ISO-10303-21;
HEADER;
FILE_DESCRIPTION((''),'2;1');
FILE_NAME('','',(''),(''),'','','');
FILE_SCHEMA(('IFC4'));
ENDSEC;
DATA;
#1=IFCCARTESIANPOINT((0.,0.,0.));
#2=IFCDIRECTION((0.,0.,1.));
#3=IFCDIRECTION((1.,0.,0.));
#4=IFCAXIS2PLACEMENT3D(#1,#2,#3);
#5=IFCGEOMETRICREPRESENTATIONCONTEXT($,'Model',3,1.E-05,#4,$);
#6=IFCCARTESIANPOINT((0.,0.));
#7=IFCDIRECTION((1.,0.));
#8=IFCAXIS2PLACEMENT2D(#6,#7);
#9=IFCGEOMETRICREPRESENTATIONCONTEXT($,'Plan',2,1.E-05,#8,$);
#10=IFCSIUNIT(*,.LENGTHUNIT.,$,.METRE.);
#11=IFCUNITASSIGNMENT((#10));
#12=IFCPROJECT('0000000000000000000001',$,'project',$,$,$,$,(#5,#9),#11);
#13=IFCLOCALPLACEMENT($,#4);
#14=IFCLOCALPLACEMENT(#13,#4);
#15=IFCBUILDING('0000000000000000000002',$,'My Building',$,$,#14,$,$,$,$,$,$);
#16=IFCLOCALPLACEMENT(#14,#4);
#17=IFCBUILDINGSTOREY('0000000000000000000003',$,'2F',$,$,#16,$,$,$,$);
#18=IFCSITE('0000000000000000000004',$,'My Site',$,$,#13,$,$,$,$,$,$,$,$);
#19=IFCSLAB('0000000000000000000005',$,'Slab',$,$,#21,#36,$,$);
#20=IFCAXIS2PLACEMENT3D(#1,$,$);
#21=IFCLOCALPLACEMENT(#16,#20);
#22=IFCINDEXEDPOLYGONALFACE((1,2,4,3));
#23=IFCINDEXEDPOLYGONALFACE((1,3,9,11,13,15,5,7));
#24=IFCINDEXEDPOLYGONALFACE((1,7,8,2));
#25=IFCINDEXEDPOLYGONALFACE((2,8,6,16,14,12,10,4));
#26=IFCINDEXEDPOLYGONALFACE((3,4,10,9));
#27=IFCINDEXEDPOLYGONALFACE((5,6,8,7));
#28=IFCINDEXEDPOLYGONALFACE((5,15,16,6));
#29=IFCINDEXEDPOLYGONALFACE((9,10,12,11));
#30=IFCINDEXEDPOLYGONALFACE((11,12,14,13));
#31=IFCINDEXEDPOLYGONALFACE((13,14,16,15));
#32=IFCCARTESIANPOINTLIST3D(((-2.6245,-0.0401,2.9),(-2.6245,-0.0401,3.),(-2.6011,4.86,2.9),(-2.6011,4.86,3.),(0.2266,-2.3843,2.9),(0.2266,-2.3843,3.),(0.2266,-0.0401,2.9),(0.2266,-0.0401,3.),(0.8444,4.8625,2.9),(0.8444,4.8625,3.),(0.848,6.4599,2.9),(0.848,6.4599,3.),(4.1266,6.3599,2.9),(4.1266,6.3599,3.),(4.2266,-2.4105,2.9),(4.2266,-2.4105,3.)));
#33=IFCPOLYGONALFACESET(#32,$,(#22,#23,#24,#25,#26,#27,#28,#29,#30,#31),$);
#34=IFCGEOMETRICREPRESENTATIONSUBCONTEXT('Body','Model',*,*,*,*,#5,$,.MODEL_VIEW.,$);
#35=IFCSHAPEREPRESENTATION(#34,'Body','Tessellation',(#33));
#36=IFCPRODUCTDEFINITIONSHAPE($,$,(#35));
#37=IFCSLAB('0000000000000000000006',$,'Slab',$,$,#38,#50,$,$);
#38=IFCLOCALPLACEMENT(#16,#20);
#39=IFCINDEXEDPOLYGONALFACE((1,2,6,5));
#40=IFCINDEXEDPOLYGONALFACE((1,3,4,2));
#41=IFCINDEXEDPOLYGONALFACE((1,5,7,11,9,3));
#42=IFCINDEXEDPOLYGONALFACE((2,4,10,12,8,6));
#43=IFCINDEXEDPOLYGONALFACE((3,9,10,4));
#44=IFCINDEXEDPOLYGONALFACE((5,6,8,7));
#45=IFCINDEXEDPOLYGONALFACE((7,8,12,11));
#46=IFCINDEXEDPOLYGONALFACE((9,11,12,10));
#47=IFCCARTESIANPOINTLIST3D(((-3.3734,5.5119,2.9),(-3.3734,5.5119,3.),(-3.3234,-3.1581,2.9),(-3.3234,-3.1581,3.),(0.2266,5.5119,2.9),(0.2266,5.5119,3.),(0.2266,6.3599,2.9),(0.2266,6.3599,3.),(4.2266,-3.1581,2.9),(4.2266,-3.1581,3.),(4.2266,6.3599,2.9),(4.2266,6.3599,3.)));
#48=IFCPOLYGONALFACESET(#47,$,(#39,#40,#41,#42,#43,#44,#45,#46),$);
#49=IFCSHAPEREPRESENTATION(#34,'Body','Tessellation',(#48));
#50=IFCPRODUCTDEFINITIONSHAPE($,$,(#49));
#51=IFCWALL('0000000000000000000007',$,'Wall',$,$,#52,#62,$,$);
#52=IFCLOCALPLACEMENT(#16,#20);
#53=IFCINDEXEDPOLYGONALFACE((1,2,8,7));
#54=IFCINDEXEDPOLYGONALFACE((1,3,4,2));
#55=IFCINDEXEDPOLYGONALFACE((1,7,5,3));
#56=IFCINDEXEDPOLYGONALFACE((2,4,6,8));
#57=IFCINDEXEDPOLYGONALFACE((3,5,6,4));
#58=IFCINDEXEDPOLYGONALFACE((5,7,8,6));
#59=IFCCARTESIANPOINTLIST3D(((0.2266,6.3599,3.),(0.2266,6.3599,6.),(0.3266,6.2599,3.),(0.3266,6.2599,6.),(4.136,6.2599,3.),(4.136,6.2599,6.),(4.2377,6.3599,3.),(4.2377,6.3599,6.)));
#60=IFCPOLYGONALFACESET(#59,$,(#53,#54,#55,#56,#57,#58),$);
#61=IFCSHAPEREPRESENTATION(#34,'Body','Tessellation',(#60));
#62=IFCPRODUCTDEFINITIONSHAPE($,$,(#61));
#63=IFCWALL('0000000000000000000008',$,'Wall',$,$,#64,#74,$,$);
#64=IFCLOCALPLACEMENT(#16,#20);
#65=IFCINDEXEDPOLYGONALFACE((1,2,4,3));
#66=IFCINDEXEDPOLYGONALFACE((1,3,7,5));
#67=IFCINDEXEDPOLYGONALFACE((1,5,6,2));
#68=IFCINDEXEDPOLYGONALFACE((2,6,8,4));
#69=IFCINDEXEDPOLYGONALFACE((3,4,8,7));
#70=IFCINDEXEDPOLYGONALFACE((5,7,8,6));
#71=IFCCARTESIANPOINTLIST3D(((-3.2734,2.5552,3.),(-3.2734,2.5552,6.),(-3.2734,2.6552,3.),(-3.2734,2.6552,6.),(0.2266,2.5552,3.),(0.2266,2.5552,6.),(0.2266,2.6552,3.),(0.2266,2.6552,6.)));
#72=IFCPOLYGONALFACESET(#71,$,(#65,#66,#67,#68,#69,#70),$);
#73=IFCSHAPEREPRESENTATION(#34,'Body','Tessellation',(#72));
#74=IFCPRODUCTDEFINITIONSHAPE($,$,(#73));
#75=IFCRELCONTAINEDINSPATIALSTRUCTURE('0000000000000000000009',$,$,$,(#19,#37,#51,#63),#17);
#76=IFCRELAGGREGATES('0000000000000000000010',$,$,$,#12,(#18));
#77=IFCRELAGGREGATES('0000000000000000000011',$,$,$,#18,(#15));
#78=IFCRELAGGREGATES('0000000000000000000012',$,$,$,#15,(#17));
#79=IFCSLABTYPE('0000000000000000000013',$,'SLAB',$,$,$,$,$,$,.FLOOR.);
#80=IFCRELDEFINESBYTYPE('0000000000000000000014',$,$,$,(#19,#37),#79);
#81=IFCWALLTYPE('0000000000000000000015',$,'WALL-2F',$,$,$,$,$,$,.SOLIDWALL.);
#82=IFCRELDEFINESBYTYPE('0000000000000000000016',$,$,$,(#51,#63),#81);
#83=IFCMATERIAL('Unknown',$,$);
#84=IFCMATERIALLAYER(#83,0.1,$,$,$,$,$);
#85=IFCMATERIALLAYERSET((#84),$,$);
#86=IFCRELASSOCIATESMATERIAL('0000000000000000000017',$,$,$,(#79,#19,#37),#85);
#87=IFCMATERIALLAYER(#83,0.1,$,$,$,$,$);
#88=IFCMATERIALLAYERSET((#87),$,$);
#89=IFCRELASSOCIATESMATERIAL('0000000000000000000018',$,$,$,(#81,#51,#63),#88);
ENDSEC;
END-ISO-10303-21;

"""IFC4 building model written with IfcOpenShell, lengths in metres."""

from ifc_helpers import new_model, si_unit, frame, origin_with_axes, origin_2d_with_axis, place, context, subcontext, project, spatial, line, indexed_curve, outline, extrude, material, layer, layer_set, layer_usage, type_object, element, save


model = new_model("IFC4")

# Units and contexts
model_context = context("Model", 3, precision=1e-05, world=origin_with_axes())
plan_context = context("Plan", 2, precision=1e-05, world=origin_2d_with_axis())
body_context_1 = subcontext(model_context, "Body", "Model", "MODEL_VIEW")
ifc_project = project(units=[si_unit("LENGTHUNIT", "METRE")], contexts=[model_context, plan_context])

# Site, building, storey
site_placement = place(None, origin_with_axes())
site = spatial("IfcSite", under=ifc_project, at=site_placement, Name="My Site")
building_placement = place(site_placement, origin_with_axes())
building = spatial("IfcBuilding", under=site, at=building_placement, Name="My Building")
storey_placement = place(building_placement, origin_with_axes())
storey = spatial("IfcBuildingStorey", under=building, at=storey_placement, Name="2F")

# Slabs
ifc_material = material(Name="Unknown")
ifc_layer_1 = layer(ifc_material, 0.1)
ifc_layer_set_1 = layer_set([ifc_layer_1])
ifc_layer_usage_1 = layer_usage(ifc_layer_set_1, "AXIS3", "POSITIVE", -0.1)
slab_type = type_object("IfcSlabType", Name="SLAB", PredefinedType="FLOOR", material=ifc_layer_set_1)
slab_1_placement = place(storey_placement, frame((-2.6011, 4.86, 3.0), z_axis=(0.0, 0.0, 1.0), x_axis=(1.0, 0.0, 0.0)))
element("IfcSlab", 1, at=slab_1_placement, inside=storey, type_object=slab_type, material=ifc_layer_usage_1, Name="Slab", context=body_context_1, shape_type="SweptSolid", body=[
    extrude(outline(indexed_curve([(0.0, 0.0), (3.4455, 0.0025), (3.4491, 1.5999), (6.7277, 1.4999), (6.8277, -7.2705), (2.8277, -7.2443), (2.8277, -4.9001), (-0.0234, -4.9001), (0.0, 0.0)])), frame((0.0, 0.0, -0.1), z_axis=(0.0, 0.0, 1.0), x_axis=(1.0, 0.0, 0.0)), (0.0, 0.0, 1.0), 0.1),
])
ifc_layer_usage_2 = layer_usage(ifc_layer_set_1, "AXIS3", "POSITIVE", -0.1)
slab_2_placement = place(storey_placement, frame((-3.3734, 5.5119, 3.0), z_axis=(0.0, 0.0, 1.0), x_axis=(1.0, 0.0, 0.0)))
element("IfcSlab", 2, at=slab_2_placement, inside=storey, type_object=slab_type, material=ifc_layer_usage_2, Name="Slab", context=body_context_1, shape_type="SweptSolid", body=[
    extrude(outline(indexed_curve([(0.0, 0.0), (3.6, 0.0), (3.6, 0.848), (7.6, 0.848), (7.6, -8.67), (0.05, -8.67), (0.0, 0.0)])), frame((0.0, 0.0, -0.1), z_axis=(0.0, 0.0, 1.0), x_axis=(1.0, 0.0, 0.0)), (0.0, 0.0, 1.0), 0.1),
])

# Wall
ifc_layer_2 = layer(ifc_material, 0.1)
ifc_layer_set_2 = layer_set([ifc_layer_2])
ifc_layer_usage_3 = layer_usage(ifc_layer_set_2, "AXIS2", "POSITIVE", 0.0)
wall_type_1 = type_object("IfcWallType", Name="WALL-2F", PredefinedType="SOLIDWALL", material=ifc_layer_set_2)
wall_1_placement = place(storey_placement, frame((4.2377, 6.3599, 3.0), z_axis=(0.0, 0.0, 1.0), x_axis=(-1.0, 0.0, 0.0)))
element("IfcWall", 3, at=wall_1_placement, inside=storey, type_object=wall_type_1, material=ifc_layer_usage_3, Name="Wall", context=body_context_1, shape_type="SweptSolid", body=[
    extrude(outline(indexed_curve([(0.0, 0.0), (0.1017, 0.1), (3.9111, 0.1), (4.0111, 0.0)], segments=[line(1, 2, 3, 4, 1)])), origin_with_axes(), (0.0, 0.0, 1.0), 3.0),
])

# Wall
ifc_layer_usage_4 = layer_usage(ifc_layer_set_2, "AXIS2", "POSITIVE", 0.0)
wall_2_placement = place(storey_placement, frame((-3.2734, 2.5552, 3.0), z_axis=(0.0, 0.0, 1.0), x_axis=(1.0, 0.0, 0.0)))
element("IfcWall", 4, at=wall_2_placement, inside=storey, type_object=wall_type_1, material=ifc_layer_usage_4, Name="Wall", context=body_context_1, shape_type="SweptSolid", body=[
    extrude(outline(indexed_curve([(0.0, 0.0), (0.0, 0.1), (3.5, 0.1), (3.5, 0.0)], segments=[line(1, 2, 3, 4, 1)])), origin_with_axes(), (0.0, 0.0, 1.0), 3.0),
])

save(model, "model.ifc")
